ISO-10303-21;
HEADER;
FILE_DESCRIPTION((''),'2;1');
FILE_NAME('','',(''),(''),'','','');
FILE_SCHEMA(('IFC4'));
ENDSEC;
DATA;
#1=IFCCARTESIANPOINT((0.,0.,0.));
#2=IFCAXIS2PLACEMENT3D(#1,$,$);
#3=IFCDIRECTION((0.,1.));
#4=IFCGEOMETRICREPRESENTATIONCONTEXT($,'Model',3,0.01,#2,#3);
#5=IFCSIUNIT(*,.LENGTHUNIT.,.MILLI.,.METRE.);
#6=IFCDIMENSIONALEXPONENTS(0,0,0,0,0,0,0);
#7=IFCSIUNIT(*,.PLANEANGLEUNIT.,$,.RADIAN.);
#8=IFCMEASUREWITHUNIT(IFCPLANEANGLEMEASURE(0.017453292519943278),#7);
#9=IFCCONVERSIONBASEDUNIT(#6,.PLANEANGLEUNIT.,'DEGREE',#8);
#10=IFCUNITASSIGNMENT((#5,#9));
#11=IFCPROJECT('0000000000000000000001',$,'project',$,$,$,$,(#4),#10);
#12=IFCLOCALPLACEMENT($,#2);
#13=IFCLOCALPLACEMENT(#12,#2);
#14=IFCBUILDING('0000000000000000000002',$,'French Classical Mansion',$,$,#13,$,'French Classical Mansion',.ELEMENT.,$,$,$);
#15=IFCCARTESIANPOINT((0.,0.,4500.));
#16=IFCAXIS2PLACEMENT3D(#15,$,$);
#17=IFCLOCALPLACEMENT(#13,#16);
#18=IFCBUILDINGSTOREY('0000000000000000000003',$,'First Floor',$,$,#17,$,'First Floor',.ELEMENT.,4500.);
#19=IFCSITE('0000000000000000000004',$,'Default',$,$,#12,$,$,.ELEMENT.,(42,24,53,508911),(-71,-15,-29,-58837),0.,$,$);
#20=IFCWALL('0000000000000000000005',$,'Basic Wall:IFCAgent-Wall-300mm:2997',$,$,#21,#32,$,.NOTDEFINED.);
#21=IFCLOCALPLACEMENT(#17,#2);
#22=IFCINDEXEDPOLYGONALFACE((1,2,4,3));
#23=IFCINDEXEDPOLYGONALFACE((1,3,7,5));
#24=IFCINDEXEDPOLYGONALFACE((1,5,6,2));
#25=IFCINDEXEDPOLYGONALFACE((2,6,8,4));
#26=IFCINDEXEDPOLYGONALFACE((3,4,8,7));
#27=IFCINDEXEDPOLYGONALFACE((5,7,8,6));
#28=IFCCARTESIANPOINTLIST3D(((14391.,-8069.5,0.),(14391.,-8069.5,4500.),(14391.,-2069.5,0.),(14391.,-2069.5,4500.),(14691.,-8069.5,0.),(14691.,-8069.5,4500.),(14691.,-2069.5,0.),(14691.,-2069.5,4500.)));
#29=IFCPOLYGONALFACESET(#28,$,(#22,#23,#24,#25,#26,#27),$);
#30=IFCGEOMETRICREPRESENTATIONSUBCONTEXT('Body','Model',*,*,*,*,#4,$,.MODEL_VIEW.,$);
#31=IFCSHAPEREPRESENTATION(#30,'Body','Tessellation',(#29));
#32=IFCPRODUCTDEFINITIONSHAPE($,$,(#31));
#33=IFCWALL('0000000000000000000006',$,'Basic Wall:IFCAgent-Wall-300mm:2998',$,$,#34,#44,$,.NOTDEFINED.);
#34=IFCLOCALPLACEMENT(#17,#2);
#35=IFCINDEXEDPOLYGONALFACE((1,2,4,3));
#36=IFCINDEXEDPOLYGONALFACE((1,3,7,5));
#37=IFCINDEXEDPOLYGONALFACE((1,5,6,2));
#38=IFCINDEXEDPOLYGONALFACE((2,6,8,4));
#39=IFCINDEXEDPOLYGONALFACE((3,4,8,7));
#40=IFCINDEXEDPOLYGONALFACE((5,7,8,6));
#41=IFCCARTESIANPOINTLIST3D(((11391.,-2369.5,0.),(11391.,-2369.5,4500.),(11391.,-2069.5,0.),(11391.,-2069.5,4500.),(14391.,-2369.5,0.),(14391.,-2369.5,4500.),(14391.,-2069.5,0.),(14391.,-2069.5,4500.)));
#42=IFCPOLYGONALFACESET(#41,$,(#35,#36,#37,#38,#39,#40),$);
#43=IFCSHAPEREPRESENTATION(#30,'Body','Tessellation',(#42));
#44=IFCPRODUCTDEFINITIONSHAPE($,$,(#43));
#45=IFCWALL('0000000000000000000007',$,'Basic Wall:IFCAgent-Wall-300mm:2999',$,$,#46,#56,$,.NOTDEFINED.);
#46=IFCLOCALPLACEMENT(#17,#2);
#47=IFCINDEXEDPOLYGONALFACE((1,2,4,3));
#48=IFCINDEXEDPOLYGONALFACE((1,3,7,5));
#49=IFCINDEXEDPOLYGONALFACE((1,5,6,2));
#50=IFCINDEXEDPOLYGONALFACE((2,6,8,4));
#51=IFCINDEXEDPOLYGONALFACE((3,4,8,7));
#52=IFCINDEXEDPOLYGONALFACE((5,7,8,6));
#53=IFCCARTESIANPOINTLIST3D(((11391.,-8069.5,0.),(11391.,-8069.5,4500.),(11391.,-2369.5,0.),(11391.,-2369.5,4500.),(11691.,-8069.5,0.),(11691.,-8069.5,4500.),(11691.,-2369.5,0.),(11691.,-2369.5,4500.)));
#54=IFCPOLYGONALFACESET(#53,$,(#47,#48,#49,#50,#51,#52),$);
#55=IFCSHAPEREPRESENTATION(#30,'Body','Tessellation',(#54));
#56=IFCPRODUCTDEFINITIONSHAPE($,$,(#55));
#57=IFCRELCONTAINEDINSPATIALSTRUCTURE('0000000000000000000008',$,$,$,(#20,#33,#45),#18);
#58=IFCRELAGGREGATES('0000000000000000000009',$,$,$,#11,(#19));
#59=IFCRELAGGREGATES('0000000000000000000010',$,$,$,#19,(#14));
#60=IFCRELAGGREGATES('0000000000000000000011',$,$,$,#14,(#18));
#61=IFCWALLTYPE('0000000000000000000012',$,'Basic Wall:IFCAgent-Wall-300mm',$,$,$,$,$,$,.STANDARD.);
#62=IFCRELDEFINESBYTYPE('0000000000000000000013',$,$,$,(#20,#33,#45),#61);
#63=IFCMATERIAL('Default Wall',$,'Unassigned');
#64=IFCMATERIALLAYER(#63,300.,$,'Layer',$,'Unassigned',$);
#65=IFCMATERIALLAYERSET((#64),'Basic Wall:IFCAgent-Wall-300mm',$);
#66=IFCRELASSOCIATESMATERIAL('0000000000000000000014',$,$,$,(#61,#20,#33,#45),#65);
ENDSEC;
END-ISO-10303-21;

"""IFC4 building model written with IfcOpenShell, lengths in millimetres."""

from ifc_helpers import new_model, entity, si_unit, converted_unit, direction, frame, frame_2d, origin, place, context, subcontext, project, spatial, rectangle, extrude, material, layer, layer_set, layer_usage, type_object, element, save


model = new_model("IFC4")

# Units and contexts
model_context = context("Model", 3, precision=0.01, world=origin(), true_north=direction((0.0, 1.0)))
body_context = subcontext(model_context, "Body", "Model", "MODEL_VIEW")
ifc_project = project(units=[si_unit("LENGTHUNIT", "METRE", prefix="MILLI"), converted_unit("PLANEANGLEUNIT", "DEGREE", entity("IfcPlaneAngleMeasure", 0.017453292519943278), si_unit("PLANEANGLEUNIT", "RADIAN"), dimensions=[0, 0, 0, 0, 0, 0, 0])], contexts=[model_context])

# Site, building, storey
site_placement = place(None, origin())
site = spatial("IfcSite", under=ifc_project, at=site_placement, Name="Default", CompositionType="ELEMENT", RefLatitude=(42, 24, 53, 508911), RefLongitude=(-71, -15, -29, -58837), RefElevation=0.0)
building_placement = place(site_placement, origin())
building = spatial("IfcBuilding", under=site, at=building_placement, Name="French Classical Mansion", LongName="French Classical Mansion", CompositionType="ELEMENT")
storey_placement = place(building_placement, frame((0.0, 0.0, 4500.0)))
storey = spatial("IfcBuildingStorey", under=building, at=storey_placement, Name="First Floor", LongName="First Floor", CompositionType="ELEMENT", Elevation=4500.0)

# Shared definitions
ifc_material = material(Name="Default Wall", Category="Unassigned")
ifc_layer = layer(ifc_material, 300.0, Name="Layer", Category="Unassigned")
ifc_layer_set = layer_set([ifc_layer], Name="Basic Wall:IFCAgent-Wall-300mm")
wall_type = type_object("IfcWallType", Name="Basic Wall:IFCAgent-Wall-300mm", PredefinedType="STANDARD", material=ifc_layer_set)

# Walls
ifc_layer_usage_1 = layer_usage(ifc_layer_set, "AXIS2", "NEGATIVE", 150.0)
wall_1_placement = place(storey_placement, frame((14541.0, -8069.5, 0.0), z_axis=(0.0, 0.0, 1.0), x_axis=(0.0, 1.0, 0.0)))
element("IfcWall", 1, at=wall_1_placement, inside=storey, type_object=wall_type, material=ifc_layer_usage_1, Name="Basic Wall:IFCAgent-Wall-300mm:2997", PredefinedType="NOTDEFINED", context=body_context, shape_type="SweptSolid", body=[
    extrude(rectangle(XDim=6000.0, YDim=300.0, at=frame_2d((3000.0, 0.0), x_axis=(-1.0, 0.0))), origin(), (0.0, 0.0, 1.0), 4500.0),
])
ifc_layer_usage_2 = layer_usage(ifc_layer_set, "AXIS2", "NEGATIVE", 150.0)
wall_2_placement = place(storey_placement, frame((14391.0, -2219.5, 0.0), z_axis=(0.0, 0.0, 1.0), x_axis=(-1.0, 0.0, 0.0)))
element("IfcWall", 2, at=wall_2_placement, inside=storey, type_object=wall_type, material=ifc_layer_usage_2, Name="Basic Wall:IFCAgent-Wall-300mm:2998", PredefinedType="NOTDEFINED", context=body_context, shape_type="SweptSolid", body=[
    extrude(rectangle(XDim=3000.0, YDim=300.0, at=frame_2d((1500.0, 0.0), x_axis=(-1.0, 0.0))), origin(), (0.0, 0.0, 1.0), 4500.0),
])
ifc_layer_usage_3 = layer_usage(ifc_layer_set, "AXIS2", "NEGATIVE", 150.0)
wall_3_placement = place(storey_placement, frame((11541.0, -2369.5, 0.0), z_axis=(0.0, 0.0, 1.0), x_axis=(0.0, -1.0, 0.0)))
element("IfcWall", 3, at=wall_3_placement, inside=storey, type_object=wall_type, material=ifc_layer_usage_3, Name="Basic Wall:IFCAgent-Wall-300mm:2999", PredefinedType="NOTDEFINED", context=body_context, shape_type="SweptSolid", body=[
    extrude(rectangle(XDim=5700.0, YDim=300.0, at=frame_2d((2850.0, 0.0), x_axis=(-1.0, 0.0))), origin(), (0.0, 0.0, 1.0), 4500.0),
])

save(model, "model.ifc")
